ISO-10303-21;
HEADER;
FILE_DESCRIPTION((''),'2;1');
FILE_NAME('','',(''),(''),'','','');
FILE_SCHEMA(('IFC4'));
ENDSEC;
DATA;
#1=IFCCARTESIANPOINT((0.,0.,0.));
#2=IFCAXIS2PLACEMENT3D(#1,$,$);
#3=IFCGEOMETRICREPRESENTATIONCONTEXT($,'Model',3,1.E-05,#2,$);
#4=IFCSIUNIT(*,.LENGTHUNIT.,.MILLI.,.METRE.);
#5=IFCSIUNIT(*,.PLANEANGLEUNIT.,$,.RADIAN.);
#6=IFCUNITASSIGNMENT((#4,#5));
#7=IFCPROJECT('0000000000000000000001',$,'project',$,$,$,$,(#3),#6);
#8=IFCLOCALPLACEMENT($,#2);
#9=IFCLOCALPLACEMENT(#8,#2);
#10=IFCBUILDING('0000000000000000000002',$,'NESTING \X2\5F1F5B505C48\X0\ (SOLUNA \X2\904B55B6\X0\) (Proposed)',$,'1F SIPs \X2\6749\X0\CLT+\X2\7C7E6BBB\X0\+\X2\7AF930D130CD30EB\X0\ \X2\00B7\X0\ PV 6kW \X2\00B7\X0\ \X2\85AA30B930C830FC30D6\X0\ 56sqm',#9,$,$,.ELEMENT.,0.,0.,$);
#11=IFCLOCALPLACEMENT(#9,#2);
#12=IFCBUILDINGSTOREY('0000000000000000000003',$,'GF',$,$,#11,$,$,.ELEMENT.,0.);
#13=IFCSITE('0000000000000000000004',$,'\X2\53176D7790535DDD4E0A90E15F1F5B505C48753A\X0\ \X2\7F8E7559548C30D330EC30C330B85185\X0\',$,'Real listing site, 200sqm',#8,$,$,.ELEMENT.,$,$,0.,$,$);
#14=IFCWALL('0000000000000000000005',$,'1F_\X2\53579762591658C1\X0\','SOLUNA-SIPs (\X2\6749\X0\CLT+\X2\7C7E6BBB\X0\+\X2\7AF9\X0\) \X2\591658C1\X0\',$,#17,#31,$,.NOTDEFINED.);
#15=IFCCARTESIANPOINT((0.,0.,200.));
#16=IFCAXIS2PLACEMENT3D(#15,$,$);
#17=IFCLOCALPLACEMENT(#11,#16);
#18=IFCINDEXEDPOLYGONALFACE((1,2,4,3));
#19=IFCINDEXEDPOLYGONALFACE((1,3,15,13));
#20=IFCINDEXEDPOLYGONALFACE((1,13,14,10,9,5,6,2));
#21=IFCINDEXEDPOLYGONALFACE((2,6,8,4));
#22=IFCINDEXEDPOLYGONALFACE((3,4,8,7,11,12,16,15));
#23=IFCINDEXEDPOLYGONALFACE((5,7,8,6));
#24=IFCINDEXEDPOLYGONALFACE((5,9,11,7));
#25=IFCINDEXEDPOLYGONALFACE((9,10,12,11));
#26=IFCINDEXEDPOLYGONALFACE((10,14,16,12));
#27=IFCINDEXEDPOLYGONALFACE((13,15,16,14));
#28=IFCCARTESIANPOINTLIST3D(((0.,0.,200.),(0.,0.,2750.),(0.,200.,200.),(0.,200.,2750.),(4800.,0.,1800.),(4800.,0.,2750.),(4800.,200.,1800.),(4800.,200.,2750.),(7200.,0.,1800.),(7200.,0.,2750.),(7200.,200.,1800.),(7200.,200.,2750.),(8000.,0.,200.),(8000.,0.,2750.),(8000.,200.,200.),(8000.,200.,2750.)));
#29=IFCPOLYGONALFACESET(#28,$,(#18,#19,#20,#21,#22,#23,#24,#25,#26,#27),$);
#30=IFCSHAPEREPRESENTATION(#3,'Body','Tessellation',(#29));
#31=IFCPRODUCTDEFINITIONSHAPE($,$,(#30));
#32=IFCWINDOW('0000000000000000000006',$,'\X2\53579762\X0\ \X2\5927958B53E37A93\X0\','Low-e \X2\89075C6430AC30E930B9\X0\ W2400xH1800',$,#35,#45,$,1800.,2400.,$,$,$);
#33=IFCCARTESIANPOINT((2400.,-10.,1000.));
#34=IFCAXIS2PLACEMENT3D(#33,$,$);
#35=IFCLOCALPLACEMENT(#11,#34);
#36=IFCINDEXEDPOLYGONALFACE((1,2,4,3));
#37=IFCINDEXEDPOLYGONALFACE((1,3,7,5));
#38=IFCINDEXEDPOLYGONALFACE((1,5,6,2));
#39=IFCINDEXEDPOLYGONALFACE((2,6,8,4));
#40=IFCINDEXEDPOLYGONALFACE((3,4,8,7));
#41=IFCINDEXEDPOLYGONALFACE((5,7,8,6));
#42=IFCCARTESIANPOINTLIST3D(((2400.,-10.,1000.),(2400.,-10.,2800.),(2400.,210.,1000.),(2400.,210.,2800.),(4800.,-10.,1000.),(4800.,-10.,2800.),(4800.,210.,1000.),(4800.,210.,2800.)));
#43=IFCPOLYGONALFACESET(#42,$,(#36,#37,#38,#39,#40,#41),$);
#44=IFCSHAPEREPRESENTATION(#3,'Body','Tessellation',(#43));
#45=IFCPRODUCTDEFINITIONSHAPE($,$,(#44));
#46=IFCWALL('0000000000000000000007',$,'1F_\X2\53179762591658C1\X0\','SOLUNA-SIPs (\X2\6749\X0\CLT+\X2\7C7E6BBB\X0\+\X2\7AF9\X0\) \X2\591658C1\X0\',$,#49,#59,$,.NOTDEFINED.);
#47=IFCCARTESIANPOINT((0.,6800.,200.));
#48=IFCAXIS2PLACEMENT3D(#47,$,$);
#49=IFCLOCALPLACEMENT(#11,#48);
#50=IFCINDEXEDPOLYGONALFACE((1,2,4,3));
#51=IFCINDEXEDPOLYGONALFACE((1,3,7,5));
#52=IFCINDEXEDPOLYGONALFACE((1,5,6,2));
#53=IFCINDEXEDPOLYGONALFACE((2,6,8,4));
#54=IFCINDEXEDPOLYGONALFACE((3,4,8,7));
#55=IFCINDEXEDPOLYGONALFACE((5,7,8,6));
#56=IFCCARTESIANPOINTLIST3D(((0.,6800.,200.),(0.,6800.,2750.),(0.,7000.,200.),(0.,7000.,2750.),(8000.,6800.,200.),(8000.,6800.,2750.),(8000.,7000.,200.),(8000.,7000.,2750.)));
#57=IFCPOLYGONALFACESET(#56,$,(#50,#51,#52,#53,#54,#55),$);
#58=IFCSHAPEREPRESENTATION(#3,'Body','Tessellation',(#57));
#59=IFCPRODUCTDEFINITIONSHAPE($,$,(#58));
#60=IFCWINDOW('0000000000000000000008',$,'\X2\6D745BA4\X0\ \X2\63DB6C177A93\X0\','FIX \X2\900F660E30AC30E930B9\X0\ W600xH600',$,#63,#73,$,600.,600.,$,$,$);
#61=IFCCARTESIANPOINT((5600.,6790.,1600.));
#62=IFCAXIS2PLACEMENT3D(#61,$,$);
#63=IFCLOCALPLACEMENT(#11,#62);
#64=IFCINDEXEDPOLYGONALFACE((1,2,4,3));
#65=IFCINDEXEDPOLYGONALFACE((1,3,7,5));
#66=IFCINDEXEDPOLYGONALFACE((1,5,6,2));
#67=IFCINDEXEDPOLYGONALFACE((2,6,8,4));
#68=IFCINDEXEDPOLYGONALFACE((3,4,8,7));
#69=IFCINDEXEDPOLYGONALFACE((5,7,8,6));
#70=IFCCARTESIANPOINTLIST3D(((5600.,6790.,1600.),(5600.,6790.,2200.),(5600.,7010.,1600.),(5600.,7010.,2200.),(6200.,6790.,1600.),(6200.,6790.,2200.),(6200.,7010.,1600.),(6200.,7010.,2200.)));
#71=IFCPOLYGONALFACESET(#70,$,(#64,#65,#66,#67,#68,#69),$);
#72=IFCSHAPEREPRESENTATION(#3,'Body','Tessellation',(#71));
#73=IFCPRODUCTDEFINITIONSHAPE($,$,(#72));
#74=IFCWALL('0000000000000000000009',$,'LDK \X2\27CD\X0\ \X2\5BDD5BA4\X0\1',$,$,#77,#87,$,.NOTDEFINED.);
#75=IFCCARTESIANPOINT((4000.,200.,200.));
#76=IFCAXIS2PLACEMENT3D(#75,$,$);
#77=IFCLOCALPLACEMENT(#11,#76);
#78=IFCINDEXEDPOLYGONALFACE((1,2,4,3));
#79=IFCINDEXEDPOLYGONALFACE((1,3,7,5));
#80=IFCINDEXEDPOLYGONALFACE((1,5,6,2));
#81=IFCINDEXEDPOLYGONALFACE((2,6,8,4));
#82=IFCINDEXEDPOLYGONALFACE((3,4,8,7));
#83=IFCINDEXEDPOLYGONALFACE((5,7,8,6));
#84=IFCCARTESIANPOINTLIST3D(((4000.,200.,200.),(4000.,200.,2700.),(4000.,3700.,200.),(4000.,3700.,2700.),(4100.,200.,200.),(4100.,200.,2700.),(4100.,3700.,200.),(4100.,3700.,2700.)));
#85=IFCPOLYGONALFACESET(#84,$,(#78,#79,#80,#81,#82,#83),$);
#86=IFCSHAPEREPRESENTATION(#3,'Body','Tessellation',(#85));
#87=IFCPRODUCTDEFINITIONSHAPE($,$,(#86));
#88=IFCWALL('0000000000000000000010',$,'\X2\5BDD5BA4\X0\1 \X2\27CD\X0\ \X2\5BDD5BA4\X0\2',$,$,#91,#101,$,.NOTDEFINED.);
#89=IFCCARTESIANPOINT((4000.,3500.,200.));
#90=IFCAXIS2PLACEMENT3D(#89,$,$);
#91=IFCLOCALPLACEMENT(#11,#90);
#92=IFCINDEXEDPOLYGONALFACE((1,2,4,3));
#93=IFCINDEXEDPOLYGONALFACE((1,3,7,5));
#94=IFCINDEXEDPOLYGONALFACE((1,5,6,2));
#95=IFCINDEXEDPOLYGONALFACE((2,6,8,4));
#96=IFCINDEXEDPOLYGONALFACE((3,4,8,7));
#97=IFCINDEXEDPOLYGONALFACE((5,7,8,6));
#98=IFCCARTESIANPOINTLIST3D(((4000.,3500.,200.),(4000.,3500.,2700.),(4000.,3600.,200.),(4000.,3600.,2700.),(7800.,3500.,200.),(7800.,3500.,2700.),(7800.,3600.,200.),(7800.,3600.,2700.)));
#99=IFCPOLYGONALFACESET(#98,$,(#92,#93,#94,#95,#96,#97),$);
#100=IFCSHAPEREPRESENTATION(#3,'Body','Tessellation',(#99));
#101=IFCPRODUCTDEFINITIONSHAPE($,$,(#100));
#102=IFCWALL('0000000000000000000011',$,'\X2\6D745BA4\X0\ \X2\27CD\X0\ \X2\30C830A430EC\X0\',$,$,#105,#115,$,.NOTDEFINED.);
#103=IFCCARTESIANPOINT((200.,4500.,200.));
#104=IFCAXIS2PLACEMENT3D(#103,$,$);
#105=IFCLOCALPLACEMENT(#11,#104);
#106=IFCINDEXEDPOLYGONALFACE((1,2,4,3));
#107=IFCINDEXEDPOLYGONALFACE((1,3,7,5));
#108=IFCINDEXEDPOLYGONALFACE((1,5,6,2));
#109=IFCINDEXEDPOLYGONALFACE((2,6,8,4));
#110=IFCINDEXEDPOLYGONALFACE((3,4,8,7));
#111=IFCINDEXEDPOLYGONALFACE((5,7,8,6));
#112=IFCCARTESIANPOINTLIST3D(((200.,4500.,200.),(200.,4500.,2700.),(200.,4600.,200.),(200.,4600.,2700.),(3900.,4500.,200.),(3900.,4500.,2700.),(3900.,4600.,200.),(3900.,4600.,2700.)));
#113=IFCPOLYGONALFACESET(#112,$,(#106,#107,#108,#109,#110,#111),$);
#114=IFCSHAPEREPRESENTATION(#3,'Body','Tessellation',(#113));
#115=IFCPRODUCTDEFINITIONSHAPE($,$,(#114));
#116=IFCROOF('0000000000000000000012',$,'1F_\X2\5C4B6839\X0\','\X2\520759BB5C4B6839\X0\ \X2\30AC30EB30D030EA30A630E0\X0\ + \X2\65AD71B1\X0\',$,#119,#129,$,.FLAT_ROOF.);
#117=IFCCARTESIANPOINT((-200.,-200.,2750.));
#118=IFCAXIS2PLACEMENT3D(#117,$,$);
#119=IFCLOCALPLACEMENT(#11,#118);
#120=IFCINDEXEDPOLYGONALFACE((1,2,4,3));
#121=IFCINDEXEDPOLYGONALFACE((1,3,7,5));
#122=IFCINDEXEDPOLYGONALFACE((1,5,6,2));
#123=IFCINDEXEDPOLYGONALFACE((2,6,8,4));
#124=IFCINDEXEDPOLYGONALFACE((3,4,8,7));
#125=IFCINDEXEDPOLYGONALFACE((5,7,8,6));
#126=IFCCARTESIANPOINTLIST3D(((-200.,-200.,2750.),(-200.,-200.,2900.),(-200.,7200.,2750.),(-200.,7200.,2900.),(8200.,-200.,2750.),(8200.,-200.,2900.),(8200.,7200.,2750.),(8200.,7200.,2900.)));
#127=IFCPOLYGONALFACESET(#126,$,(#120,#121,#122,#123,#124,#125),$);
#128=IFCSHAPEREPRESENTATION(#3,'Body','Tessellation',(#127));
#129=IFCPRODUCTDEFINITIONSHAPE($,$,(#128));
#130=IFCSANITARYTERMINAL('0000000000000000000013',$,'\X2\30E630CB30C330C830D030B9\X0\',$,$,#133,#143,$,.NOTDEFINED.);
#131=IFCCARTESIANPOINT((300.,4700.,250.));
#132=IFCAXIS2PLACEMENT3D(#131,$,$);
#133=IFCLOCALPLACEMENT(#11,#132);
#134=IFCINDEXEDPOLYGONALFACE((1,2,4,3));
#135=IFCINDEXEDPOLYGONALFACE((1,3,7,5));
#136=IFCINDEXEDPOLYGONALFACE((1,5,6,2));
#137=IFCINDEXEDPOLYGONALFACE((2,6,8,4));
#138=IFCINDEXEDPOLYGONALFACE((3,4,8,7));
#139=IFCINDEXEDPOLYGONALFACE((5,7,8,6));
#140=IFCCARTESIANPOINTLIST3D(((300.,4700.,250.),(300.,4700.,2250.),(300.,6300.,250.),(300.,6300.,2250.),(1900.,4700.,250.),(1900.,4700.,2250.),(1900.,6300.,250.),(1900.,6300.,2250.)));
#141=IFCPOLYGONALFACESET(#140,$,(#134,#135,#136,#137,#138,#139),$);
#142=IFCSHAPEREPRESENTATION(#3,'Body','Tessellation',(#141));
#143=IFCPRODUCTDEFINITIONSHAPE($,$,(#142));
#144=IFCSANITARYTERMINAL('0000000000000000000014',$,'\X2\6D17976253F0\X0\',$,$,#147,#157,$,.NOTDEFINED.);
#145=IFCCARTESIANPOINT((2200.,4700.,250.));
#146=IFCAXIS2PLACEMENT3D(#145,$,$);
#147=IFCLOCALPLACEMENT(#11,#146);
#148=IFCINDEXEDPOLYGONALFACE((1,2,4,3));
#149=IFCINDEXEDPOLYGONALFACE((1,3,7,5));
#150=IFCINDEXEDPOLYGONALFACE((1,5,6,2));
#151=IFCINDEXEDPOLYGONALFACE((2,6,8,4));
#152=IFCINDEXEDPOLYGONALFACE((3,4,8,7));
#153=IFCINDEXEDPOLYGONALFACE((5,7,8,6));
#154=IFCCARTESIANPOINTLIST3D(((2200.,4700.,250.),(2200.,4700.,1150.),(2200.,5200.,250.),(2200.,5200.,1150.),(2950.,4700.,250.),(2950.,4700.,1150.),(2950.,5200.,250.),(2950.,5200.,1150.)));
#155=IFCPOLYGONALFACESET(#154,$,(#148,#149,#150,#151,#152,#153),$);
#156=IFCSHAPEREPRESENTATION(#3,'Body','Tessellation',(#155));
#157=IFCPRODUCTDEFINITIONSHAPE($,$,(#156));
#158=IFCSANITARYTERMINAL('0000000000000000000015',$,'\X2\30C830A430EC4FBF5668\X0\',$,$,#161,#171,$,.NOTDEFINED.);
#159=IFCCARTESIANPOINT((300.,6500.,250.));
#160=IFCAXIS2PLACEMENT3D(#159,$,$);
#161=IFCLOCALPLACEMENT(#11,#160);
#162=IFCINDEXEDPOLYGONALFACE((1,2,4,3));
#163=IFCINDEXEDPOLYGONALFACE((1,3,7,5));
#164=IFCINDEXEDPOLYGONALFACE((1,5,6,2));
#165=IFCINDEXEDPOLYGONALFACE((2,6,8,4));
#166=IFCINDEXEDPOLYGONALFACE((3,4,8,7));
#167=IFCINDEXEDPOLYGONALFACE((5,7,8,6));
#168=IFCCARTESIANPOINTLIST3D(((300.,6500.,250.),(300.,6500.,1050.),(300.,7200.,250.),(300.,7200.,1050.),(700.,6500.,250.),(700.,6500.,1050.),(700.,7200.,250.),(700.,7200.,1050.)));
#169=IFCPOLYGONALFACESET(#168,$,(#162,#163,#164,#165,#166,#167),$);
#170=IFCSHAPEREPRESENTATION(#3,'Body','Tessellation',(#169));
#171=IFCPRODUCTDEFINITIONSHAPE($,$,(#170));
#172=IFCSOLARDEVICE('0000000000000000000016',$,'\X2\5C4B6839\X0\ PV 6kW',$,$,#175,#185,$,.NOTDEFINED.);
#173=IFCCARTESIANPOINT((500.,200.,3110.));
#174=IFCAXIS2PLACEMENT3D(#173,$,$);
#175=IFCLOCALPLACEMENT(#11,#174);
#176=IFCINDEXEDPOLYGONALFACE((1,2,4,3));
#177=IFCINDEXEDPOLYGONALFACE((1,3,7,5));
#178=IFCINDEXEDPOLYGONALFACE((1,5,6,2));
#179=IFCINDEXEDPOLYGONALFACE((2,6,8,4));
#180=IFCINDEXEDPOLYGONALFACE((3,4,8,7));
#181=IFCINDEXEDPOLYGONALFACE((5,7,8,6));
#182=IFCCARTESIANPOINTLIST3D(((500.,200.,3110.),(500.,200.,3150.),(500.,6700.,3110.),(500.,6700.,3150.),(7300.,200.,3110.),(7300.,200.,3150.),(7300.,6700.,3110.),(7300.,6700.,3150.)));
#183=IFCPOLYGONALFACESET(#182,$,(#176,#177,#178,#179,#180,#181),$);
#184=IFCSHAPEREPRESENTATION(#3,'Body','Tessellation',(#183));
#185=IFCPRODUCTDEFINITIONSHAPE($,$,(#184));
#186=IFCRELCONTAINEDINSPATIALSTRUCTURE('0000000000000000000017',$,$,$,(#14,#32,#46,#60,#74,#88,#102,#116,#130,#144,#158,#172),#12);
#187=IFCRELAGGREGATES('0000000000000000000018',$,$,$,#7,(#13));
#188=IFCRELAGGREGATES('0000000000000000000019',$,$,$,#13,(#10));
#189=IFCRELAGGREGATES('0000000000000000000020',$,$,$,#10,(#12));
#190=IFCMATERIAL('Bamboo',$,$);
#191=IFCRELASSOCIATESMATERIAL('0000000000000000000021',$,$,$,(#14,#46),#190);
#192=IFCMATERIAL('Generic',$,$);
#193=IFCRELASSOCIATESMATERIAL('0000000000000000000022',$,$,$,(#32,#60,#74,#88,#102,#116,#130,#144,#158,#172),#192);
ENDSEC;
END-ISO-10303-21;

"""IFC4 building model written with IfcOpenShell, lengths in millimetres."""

from ifc_helpers import new_model, si_unit, frame, frame_2d, origin, place, context, project, spatial, rectangle, extrude, material, element, fill, save


model = new_model("IFC4")

# Units and contexts
model_context = context("Model", 3, precision=1e-05, world=origin())
ifc_project = project(units=[si_unit("LENGTHUNIT", "METRE", prefix="MILLI"), si_unit("PLANEANGLEUNIT", "RADIAN")], contexts=[model_context])

# Site, building, storey
site_placement = place(None, origin())
site = spatial("IfcSite", under=ifc_project, at=site_placement, Name="北海道川上郡弟子屈町 美留和ビレッジ内", ObjectType="Real listing site, 200sqm", CompositionType="ELEMENT", RefElevation=0.0)
building_placement = place(site_placement, origin())
building = spatial("IfcBuilding", under=site, at=building_placement, Name="NESTING 弟子屈 (SOLUNA 運営) (Proposed)", ObjectType="1F SIPs 杉CLT+籾殻+竹パネル · PV 6kW · 薪ストーブ 56sqm", CompositionType="ELEMENT", ElevationOfRefHeight=0.0, ElevationOfTerrain=0.0)
storey_placement = place(building_placement, origin())
storey = spatial("IfcBuildingStorey", under=building, at=storey_placement, Name="GF", CompositionType="ELEMENT", Elevation=0.0)

# Walls, openings, windows
ifc_material_1 = material(Name="Bamboo")
wall_1_placement = place(storey_placement, frame((0.0, 0.0, 200.0)))
wall_1 = element("IfcWall", 1, at=wall_1_placement, inside=storey, material=ifc_material_1, Name="1F_南面外壁", Description="SOLUNA-SIPs (杉CLT+籾殻+竹) 外壁", PredefinedType="NOTDEFINED", context=model_context, shape_type="SweptSolid", body=[
    extrude(rectangle(XDim=8000.0, YDim=200.0, at=frame_2d((4000.0, 100.0))), frame((0.0, 0.0, 200.0)), (0.0, 0.0, 1.0), 2550.0),
])
opening_1_placement = place(storey_placement, frame((2400.0, -10.0, 1000.0)))
opening_1 = element("IfcOpeningElement", 2, at=opening_1_placement, cuts=wall_1, PredefinedType="NOTDEFINED", context=model_context, shape_type="SweptSolid", body=[
    extrude(rectangle(XDim=2400.0, YDim=220.0, at=frame_2d((1200.0, 110.0))), frame((2400.0, -10.0, 1000.0)), (0.0, 0.0, 1.0), 1800.0),
])
ifc_material_2 = material(Name="Generic")
window_1_placement = place(storey_placement, frame((2400.0, -10.0, 1000.0)))
window_1 = element("IfcWindow", 3, at=window_1_placement, inside=storey, material=ifc_material_2, Name="南面 大開口窓", Description="Low-e 複層ガラス W2400xH1800", OverallHeight=1800.0, OverallWidth=2400.0, context=model_context, shape_type="SweptSolid", body=[
    extrude(rectangle(XDim=2400.0, YDim=220.0, at=frame_2d((1200.0, 110.0))), frame((2400.0, -10.0, 1000.0)), (0.0, 0.0, 1.0), 1800.0),
])
fill(opening_1, window_1)
wall_2_placement = place(storey_placement, frame((0.0, 6800.0, 200.0)))
wall_2 = element("IfcWall", 4, at=wall_2_placement, inside=storey, material=ifc_material_1, Name="1F_北面外壁", Description="SOLUNA-SIPs (杉CLT+籾殻+竹) 外壁", PredefinedType="NOTDEFINED", context=model_context, shape_type="SweptSolid", body=[
    extrude(rectangle(XDim=8000.0, YDim=200.0, at=frame_2d((4000.0, 100.0))), frame((0.0, 6800.0, 200.0)), (0.0, 0.0, 1.0), 2550.0),
])
opening_2_placement = place(storey_placement, frame((5600.0, 6790.0, 1600.0)))
opening_2 = element("IfcOpeningElement", 5, at=opening_2_placement, cuts=wall_2, PredefinedType="NOTDEFINED", context=model_context, shape_type="SweptSolid", body=[
    extrude(rectangle(XDim=600.0, YDim=220.0, at=frame_2d((300.0, 110.0))), frame((5600.0, 6790.0, 1600.0)), (0.0, 0.0, 1.0), 600.0),
])
window_2_placement = place(storey_placement, frame((5600.0, 6790.0, 1600.0)))
window_2 = element("IfcWindow", 6, at=window_2_placement, inside=storey, material=ifc_material_2, Name="浴室 換気窓", Description="FIX 透明ガラス W600xH600", OverallHeight=600.0, OverallWidth=600.0, context=model_context, shape_type="SweptSolid", body=[
    extrude(rectangle(XDim=600.0, YDim=220.0, at=frame_2d((300.0, 110.0))), frame((5600.0, 6790.0, 1600.0)), (0.0, 0.0, 1.0), 600.0),
])
fill(opening_2, window_2)

# Walls
wall_3_placement = place(storey_placement, frame((4000.0, 200.0, 200.0)))
element("IfcWall", 7, at=wall_3_placement, inside=storey, material=ifc_material_2, Name="LDK ⟍ 寝室1", PredefinedType="NOTDEFINED", context=model_context, shape_type="SweptSolid", body=[
    extrude(rectangle(XDim=100.0, YDim=3500.0, at=frame_2d((50.0, 1750.0))), frame((4000.0, 200.0, 200.0)), (0.0, 0.0, 1.0), 2500.0),
])
wall_4_placement = place(storey_placement, frame((4000.0, 3500.0, 200.0)))
element("IfcWall", 8, at=wall_4_placement, inside=storey, material=ifc_material_2, Name="寝室1 ⟍ 寝室2", PredefinedType="NOTDEFINED", context=model_context, shape_type="SweptSolid", body=[
    extrude(rectangle(XDim=3800.0, YDim=100.0, at=frame_2d((1900.0, 50.0))), frame((4000.0, 3500.0, 200.0)), (0.0, 0.0, 1.0), 2500.0),
])
wall_5_placement = place(storey_placement, frame((200.0, 4500.0, 200.0)))
element("IfcWall", 9, at=wall_5_placement, inside=storey, material=ifc_material_2, Name="浴室 ⟍ トイレ", PredefinedType="NOTDEFINED", context=model_context, shape_type="SweptSolid", body=[
    extrude(rectangle(XDim=3700.0, YDim=100.0, at=frame_2d((1850.0, 50.0))), frame((200.0, 4500.0, 200.0)), (0.0, 0.0, 1.0), 2500.0),
])

# Roof
roof_placement = place(storey_placement, frame((-200.0, -200.0, 2750.0)))
element("IfcRoof", 10, at=roof_placement, inside=storey, material=ifc_material_2, Name="1F_屋根", Description="切妻屋根 ガルバリウム + 断熱", PredefinedType="FLAT_ROOF", context=model_context, shape_type="SweptSolid", body=[
    extrude(rectangle(XDim=8400.0, YDim=7400.0, at=frame_2d((4200.0, 3700.0))), frame((-200.0, -200.0, 2750.0)), (0.0, 0.0, 1.0), 150.0),
])

# Sanitary terminals
sanitary_terminal_1_placement = place(storey_placement, frame((300.0, 4700.0, 250.0)))
element("IfcSanitaryTerminal", 11, at=sanitary_terminal_1_placement, inside=storey, material=ifc_material_2, Name="ユニットバス", PredefinedType="NOTDEFINED", context=model_context, shape_type="SweptSolid", body=[
    extrude(rectangle(XDim=1600.0, YDim=1600.0, at=frame_2d((800.0, 800.0))), frame((300.0, 4700.0, 250.0)), (0.0, 0.0, 1.0), 2000.0),
])
sanitary_terminal_2_placement = place(storey_placement, frame((2200.0, 4700.0, 250.0)))
element("IfcSanitaryTerminal", 12, at=sanitary_terminal_2_placement, inside=storey, material=ifc_material_2, Name="洗面台", PredefinedType="NOTDEFINED", context=model_context, shape_type="SweptSolid", body=[
    extrude(rectangle(XDim=750.0, YDim=500.0, at=frame_2d((375.0, 250.0))), frame((2200.0, 4700.0, 250.0)), (0.0, 0.0, 1.0), 900.0),
])
sanitary_terminal_3_placement = place(storey_placement, frame((300.0, 6500.0, 250.0)))
element("IfcSanitaryTerminal", 13, at=sanitary_terminal_3_placement, inside=storey, material=ifc_material_2, Name="トイレ便器", PredefinedType="NOTDEFINED", context=model_context, shape_type="SweptSolid", body=[
    extrude(rectangle(XDim=400.0, YDim=700.0, at=frame_2d((200.0, 350.0))), frame((300.0, 6500.0, 250.0)), (0.0, 0.0, 1.0), 800.0),
])

# Solar device
solar_device_placement = place(storey_placement, frame((500.0, 200.0, 3110.0)))
element("IfcSolarDevice", 14, at=solar_device_placement, inside=storey, material=ifc_material_2, Name="屋根 PV 6kW", PredefinedType="NOTDEFINED", context=model_context, shape_type="SweptSolid", body=[
    extrude(rectangle(XDim=6800.0, YDim=6500.0, at=frame_2d((3400.0, 3250.0))), frame((500.0, 200.0, 3110.0)), (0.0, 0.0, 1.0), 40.0),
])

save(model, "model.ifc")
